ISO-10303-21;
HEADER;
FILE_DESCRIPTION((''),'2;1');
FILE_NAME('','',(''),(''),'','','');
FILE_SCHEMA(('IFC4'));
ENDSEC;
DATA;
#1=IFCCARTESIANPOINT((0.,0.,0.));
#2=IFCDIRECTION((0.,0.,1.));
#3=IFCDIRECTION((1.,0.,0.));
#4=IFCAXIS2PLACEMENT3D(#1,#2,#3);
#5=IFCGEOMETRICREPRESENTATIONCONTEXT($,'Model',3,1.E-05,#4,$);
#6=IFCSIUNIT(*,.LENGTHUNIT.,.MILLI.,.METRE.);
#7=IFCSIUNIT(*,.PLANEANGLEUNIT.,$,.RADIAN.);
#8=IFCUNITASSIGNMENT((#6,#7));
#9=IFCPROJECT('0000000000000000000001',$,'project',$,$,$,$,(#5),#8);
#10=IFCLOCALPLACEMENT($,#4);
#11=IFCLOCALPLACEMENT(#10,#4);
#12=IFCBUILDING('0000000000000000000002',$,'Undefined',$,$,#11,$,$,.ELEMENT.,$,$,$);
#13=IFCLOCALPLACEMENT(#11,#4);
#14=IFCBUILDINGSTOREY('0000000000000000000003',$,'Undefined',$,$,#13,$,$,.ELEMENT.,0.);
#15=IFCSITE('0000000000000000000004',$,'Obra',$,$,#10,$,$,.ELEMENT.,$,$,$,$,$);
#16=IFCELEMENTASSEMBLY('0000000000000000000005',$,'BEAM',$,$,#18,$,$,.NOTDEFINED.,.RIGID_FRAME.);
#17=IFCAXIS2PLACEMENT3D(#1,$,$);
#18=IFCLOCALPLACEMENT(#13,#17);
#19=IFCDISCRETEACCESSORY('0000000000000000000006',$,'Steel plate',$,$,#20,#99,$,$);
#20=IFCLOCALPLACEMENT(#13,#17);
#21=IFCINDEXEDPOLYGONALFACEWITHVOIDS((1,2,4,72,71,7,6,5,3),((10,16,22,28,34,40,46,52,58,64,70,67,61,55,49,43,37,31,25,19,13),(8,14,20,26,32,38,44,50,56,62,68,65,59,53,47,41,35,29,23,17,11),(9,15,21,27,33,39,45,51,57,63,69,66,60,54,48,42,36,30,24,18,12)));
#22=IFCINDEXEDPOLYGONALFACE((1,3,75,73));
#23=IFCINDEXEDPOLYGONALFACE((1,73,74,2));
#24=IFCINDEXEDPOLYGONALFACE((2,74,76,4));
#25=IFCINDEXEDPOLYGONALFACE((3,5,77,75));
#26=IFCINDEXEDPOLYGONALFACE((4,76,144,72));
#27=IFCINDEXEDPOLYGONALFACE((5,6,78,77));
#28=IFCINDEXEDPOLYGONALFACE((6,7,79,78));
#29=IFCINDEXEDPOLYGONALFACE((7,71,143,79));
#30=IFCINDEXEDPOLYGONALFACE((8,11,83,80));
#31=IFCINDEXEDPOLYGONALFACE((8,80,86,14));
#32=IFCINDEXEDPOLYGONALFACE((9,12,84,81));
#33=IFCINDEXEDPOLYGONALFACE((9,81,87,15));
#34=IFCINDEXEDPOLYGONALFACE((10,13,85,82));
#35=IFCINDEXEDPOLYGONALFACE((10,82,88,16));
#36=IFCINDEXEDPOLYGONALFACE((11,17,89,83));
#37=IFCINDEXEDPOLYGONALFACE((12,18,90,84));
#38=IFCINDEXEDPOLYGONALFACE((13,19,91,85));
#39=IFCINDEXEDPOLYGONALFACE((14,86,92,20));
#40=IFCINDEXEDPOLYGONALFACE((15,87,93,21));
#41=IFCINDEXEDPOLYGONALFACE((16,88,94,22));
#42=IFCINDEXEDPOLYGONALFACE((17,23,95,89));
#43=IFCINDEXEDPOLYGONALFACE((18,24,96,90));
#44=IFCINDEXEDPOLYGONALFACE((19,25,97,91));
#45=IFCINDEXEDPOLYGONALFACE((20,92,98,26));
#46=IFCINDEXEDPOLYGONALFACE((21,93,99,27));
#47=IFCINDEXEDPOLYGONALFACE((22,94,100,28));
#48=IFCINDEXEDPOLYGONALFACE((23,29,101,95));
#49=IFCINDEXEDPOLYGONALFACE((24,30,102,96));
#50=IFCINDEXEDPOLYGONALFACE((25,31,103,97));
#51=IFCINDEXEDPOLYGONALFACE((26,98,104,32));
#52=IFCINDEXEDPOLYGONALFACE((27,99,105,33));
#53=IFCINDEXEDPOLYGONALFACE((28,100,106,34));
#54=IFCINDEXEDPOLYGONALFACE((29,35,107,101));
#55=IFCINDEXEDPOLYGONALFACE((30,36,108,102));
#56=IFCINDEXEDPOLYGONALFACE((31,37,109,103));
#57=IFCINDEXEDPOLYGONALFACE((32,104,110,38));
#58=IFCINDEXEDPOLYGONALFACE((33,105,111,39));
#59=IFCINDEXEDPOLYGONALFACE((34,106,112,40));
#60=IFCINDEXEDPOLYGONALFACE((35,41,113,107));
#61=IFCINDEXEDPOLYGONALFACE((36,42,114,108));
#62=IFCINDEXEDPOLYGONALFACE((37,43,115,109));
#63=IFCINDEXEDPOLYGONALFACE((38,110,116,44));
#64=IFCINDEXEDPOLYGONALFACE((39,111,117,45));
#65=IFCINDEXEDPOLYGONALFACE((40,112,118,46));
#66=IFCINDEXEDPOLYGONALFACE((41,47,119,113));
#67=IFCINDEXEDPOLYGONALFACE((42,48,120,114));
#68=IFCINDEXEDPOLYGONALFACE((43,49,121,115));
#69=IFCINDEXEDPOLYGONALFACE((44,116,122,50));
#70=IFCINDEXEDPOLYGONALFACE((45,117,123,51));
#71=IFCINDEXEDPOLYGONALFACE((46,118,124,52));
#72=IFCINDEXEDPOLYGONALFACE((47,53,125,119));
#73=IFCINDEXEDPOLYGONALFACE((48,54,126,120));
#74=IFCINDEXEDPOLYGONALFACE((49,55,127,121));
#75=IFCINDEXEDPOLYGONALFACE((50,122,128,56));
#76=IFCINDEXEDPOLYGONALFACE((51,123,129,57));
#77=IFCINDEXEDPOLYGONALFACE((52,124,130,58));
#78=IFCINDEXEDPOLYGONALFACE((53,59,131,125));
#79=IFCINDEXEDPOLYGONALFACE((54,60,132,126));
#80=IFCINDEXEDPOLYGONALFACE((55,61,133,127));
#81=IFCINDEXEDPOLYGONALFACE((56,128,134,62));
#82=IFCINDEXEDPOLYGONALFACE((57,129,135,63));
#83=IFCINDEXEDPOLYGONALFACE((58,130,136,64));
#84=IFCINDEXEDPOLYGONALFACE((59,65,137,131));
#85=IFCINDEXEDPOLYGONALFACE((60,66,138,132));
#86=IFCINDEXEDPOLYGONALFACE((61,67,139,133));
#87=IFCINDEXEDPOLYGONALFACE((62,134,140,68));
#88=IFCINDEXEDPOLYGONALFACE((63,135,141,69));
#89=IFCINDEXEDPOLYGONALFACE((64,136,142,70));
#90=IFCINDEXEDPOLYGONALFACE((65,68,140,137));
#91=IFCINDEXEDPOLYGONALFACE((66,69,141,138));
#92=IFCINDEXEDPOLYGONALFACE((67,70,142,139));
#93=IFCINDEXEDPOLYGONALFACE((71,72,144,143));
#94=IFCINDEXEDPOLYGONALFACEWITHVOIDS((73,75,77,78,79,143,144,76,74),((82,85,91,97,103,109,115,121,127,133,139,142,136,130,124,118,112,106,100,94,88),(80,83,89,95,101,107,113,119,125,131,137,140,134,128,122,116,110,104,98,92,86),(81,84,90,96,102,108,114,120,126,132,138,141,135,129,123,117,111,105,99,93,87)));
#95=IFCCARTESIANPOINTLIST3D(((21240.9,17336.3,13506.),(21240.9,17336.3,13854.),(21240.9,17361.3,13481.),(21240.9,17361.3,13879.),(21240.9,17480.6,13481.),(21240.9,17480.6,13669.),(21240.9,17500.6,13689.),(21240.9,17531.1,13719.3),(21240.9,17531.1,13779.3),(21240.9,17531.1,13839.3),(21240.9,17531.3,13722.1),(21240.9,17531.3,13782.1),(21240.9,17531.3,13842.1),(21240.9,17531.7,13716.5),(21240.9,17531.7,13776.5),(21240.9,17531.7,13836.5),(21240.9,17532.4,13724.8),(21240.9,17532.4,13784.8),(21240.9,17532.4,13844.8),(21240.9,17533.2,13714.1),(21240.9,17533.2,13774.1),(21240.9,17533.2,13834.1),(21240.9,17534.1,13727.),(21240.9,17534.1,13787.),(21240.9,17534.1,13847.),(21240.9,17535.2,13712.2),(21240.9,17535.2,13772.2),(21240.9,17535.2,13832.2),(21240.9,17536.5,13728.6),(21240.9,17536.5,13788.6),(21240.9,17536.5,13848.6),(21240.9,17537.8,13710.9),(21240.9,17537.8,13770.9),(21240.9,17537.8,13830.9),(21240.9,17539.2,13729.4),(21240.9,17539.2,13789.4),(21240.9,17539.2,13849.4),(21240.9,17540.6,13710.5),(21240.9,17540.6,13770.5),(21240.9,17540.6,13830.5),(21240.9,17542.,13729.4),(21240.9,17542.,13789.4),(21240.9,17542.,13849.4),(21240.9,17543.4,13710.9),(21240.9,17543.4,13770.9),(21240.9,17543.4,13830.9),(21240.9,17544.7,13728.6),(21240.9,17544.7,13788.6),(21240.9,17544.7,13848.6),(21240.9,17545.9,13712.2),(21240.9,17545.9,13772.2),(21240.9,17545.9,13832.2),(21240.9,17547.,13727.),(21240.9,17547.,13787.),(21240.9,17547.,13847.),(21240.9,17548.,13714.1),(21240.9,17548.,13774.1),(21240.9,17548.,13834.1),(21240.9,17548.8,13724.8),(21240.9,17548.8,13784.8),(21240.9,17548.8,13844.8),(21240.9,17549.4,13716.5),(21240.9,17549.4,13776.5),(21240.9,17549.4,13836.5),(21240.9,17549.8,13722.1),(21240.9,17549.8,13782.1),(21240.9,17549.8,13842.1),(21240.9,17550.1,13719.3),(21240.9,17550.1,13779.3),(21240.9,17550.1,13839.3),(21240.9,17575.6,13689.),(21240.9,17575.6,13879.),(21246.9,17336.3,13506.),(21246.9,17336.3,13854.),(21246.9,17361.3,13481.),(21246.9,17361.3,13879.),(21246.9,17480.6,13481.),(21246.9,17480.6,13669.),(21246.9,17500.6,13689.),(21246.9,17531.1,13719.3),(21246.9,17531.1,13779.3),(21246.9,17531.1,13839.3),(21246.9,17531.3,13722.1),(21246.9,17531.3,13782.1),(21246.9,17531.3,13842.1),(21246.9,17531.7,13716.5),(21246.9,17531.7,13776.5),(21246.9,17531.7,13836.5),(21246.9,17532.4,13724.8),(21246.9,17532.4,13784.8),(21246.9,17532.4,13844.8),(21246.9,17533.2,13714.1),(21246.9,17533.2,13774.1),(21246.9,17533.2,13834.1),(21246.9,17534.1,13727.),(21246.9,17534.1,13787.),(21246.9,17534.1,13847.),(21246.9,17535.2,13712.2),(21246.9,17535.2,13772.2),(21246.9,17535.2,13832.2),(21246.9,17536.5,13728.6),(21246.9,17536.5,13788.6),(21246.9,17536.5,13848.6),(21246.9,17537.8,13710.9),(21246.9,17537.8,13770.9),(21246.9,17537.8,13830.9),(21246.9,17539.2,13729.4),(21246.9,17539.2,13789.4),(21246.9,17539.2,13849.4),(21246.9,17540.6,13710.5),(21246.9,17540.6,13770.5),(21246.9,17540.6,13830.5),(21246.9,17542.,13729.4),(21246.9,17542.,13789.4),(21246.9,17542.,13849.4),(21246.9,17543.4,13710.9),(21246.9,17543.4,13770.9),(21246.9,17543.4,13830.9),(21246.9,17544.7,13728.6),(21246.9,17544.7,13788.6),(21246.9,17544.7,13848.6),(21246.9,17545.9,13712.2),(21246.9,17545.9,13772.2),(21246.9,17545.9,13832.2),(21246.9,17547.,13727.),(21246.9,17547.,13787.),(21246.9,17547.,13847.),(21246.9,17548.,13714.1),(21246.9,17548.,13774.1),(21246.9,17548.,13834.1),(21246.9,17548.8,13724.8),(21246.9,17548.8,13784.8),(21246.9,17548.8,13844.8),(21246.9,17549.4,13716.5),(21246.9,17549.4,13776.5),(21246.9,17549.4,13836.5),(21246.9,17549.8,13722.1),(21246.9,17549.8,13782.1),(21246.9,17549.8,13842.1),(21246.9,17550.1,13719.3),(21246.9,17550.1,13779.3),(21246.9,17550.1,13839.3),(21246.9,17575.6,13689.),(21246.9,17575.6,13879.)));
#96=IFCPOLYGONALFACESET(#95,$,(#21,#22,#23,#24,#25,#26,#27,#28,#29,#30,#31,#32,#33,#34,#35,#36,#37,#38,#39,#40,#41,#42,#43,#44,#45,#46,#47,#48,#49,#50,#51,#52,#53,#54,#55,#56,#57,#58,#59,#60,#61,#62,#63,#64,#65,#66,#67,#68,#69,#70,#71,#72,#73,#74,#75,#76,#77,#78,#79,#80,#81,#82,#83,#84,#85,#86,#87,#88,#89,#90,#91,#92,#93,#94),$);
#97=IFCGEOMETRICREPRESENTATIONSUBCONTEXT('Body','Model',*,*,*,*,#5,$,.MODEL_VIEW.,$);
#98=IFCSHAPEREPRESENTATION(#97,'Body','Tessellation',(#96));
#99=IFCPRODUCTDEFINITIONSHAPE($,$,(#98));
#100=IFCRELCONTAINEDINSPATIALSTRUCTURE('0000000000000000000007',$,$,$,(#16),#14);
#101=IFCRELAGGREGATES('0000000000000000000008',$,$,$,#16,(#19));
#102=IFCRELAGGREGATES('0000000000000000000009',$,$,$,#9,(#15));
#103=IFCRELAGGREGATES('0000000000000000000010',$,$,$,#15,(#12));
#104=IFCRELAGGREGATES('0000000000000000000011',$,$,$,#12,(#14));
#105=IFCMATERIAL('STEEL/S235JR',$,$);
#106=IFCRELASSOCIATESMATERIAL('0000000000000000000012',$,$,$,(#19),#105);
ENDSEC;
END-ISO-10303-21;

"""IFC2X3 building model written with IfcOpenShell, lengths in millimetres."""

from ifc_helpers import new_model, si_unit, frame, origin_with_axes, origin_2d_with_axis, place, context, subcontext, project, spatial, polyline, circle, outline, extrude, source, transform, mapped, material, element, aggregate, save


model = new_model("IFC2X3")

# Units and contexts
model_context = context("Model", 3, precision=1e-05, world=origin_with_axes())
body_context = subcontext(model_context, "Body", "Model", "MODEL_VIEW")
ifc_project = project(units=[si_unit("LENGTHUNIT", "METRE", prefix="MILLI"), si_unit("PLANEANGLEUNIT", "RADIAN")], contexts=[model_context])

# Site, building, storey
site_placement = place(None, origin_with_axes())
site = spatial("IfcSite", under=ifc_project, at=site_placement, Name="Obra", CompositionType="ELEMENT")
building_placement = place(site_placement, origin_with_axes())
building = spatial("IfcBuilding", under=site, at=building_placement, Name="Undefined", CompositionType="ELEMENT")
storey_placement = place(building_placement, origin_with_axes())
storey = spatial("IfcBuildingStorey", under=building, at=storey_placement, Name="Undefined", CompositionType="ELEMENT", Elevation=0.0)

# Shared definitions
ifc_material_1 = material(Name="STEEL/S235JR")

# Element assembly
assembly_1_placement = place(storey_placement, origin_with_axes())
assembly_1 = element("IfcElementAssembly", 1, at=assembly_1_placement, inside=storey, Name="BEAM", AssemblyPlace="NOTDEFINED", PredefinedType="RIGID_FRAME")

# Discrete accessory, opening
shared_shape_1 = source(origin_with_axes(), body_context, "Body", "SweptSolid", [
    extrude(circle(Radius=9.5, at=origin_2d_with_axis()), frame((0.0, 3.0, 0.0), z_axis=(0.0, 1.0, 0.0), x_axis=(1.0, 0.0, 0.0)), (0.0, 0.0, 1.0), 6.2),
])
discrete_accessory_1_placement = place(assembly_1_placement, frame((21243.9, 17336.3, 13506.0), z_axis=(1.0, -0.000129, 0.0), x_axis=(0.000091, 0.707107, -0.707107)))
discrete_accessory_1 = element("IfcDiscreteAccessory", 2, at=discrete_accessory_1_placement, material=ifc_material_1, Name="Steel plate", context=body_context, shape_type="SweptSolid", body=[
    extrude(outline(polyline([(0.0, 0.0), (35.4, 0.0), (119.7, 84.3), (-13.3, 217.3), (-13.3, 245.5), (39.8, 298.6), (-94.6, 432.9), (-246.1, 281.4), (-246.1, 246.1), (0.0, 0.0)])), frame((0.0, 0.0, -3.0), z_axis=(0.0, 0.0, 1.0), x_axis=(1.0, 0.0, 0.0)), (0.0, 0.0, 1.0), 6.0),
])
opening_1_placement = place(assembly_1_placement, frame((21250.0, 17490.6, 13879.0), z_axis=(0.000129, 1.0, 0.0), x_axis=(0.0, 0.0, -1.0)))
element("IfcOpeningElement", 3, at=opening_1_placement, cuts=discrete_accessory_1, ObjectType="Opening", context=body_context, shape_type="MappedRepresentation", body=[
    mapped(shared_shape_1, transform((159.0, 0.0, 50.0))),
    mapped(shared_shape_1, transform((99.0, 0.0, 50.0))),
    mapped(shared_shape_1, transform((39.0, 0.0, 50.0))),
])
aggregate(assembly_1, [discrete_accessory_1])

save(model, "model.ifc")
